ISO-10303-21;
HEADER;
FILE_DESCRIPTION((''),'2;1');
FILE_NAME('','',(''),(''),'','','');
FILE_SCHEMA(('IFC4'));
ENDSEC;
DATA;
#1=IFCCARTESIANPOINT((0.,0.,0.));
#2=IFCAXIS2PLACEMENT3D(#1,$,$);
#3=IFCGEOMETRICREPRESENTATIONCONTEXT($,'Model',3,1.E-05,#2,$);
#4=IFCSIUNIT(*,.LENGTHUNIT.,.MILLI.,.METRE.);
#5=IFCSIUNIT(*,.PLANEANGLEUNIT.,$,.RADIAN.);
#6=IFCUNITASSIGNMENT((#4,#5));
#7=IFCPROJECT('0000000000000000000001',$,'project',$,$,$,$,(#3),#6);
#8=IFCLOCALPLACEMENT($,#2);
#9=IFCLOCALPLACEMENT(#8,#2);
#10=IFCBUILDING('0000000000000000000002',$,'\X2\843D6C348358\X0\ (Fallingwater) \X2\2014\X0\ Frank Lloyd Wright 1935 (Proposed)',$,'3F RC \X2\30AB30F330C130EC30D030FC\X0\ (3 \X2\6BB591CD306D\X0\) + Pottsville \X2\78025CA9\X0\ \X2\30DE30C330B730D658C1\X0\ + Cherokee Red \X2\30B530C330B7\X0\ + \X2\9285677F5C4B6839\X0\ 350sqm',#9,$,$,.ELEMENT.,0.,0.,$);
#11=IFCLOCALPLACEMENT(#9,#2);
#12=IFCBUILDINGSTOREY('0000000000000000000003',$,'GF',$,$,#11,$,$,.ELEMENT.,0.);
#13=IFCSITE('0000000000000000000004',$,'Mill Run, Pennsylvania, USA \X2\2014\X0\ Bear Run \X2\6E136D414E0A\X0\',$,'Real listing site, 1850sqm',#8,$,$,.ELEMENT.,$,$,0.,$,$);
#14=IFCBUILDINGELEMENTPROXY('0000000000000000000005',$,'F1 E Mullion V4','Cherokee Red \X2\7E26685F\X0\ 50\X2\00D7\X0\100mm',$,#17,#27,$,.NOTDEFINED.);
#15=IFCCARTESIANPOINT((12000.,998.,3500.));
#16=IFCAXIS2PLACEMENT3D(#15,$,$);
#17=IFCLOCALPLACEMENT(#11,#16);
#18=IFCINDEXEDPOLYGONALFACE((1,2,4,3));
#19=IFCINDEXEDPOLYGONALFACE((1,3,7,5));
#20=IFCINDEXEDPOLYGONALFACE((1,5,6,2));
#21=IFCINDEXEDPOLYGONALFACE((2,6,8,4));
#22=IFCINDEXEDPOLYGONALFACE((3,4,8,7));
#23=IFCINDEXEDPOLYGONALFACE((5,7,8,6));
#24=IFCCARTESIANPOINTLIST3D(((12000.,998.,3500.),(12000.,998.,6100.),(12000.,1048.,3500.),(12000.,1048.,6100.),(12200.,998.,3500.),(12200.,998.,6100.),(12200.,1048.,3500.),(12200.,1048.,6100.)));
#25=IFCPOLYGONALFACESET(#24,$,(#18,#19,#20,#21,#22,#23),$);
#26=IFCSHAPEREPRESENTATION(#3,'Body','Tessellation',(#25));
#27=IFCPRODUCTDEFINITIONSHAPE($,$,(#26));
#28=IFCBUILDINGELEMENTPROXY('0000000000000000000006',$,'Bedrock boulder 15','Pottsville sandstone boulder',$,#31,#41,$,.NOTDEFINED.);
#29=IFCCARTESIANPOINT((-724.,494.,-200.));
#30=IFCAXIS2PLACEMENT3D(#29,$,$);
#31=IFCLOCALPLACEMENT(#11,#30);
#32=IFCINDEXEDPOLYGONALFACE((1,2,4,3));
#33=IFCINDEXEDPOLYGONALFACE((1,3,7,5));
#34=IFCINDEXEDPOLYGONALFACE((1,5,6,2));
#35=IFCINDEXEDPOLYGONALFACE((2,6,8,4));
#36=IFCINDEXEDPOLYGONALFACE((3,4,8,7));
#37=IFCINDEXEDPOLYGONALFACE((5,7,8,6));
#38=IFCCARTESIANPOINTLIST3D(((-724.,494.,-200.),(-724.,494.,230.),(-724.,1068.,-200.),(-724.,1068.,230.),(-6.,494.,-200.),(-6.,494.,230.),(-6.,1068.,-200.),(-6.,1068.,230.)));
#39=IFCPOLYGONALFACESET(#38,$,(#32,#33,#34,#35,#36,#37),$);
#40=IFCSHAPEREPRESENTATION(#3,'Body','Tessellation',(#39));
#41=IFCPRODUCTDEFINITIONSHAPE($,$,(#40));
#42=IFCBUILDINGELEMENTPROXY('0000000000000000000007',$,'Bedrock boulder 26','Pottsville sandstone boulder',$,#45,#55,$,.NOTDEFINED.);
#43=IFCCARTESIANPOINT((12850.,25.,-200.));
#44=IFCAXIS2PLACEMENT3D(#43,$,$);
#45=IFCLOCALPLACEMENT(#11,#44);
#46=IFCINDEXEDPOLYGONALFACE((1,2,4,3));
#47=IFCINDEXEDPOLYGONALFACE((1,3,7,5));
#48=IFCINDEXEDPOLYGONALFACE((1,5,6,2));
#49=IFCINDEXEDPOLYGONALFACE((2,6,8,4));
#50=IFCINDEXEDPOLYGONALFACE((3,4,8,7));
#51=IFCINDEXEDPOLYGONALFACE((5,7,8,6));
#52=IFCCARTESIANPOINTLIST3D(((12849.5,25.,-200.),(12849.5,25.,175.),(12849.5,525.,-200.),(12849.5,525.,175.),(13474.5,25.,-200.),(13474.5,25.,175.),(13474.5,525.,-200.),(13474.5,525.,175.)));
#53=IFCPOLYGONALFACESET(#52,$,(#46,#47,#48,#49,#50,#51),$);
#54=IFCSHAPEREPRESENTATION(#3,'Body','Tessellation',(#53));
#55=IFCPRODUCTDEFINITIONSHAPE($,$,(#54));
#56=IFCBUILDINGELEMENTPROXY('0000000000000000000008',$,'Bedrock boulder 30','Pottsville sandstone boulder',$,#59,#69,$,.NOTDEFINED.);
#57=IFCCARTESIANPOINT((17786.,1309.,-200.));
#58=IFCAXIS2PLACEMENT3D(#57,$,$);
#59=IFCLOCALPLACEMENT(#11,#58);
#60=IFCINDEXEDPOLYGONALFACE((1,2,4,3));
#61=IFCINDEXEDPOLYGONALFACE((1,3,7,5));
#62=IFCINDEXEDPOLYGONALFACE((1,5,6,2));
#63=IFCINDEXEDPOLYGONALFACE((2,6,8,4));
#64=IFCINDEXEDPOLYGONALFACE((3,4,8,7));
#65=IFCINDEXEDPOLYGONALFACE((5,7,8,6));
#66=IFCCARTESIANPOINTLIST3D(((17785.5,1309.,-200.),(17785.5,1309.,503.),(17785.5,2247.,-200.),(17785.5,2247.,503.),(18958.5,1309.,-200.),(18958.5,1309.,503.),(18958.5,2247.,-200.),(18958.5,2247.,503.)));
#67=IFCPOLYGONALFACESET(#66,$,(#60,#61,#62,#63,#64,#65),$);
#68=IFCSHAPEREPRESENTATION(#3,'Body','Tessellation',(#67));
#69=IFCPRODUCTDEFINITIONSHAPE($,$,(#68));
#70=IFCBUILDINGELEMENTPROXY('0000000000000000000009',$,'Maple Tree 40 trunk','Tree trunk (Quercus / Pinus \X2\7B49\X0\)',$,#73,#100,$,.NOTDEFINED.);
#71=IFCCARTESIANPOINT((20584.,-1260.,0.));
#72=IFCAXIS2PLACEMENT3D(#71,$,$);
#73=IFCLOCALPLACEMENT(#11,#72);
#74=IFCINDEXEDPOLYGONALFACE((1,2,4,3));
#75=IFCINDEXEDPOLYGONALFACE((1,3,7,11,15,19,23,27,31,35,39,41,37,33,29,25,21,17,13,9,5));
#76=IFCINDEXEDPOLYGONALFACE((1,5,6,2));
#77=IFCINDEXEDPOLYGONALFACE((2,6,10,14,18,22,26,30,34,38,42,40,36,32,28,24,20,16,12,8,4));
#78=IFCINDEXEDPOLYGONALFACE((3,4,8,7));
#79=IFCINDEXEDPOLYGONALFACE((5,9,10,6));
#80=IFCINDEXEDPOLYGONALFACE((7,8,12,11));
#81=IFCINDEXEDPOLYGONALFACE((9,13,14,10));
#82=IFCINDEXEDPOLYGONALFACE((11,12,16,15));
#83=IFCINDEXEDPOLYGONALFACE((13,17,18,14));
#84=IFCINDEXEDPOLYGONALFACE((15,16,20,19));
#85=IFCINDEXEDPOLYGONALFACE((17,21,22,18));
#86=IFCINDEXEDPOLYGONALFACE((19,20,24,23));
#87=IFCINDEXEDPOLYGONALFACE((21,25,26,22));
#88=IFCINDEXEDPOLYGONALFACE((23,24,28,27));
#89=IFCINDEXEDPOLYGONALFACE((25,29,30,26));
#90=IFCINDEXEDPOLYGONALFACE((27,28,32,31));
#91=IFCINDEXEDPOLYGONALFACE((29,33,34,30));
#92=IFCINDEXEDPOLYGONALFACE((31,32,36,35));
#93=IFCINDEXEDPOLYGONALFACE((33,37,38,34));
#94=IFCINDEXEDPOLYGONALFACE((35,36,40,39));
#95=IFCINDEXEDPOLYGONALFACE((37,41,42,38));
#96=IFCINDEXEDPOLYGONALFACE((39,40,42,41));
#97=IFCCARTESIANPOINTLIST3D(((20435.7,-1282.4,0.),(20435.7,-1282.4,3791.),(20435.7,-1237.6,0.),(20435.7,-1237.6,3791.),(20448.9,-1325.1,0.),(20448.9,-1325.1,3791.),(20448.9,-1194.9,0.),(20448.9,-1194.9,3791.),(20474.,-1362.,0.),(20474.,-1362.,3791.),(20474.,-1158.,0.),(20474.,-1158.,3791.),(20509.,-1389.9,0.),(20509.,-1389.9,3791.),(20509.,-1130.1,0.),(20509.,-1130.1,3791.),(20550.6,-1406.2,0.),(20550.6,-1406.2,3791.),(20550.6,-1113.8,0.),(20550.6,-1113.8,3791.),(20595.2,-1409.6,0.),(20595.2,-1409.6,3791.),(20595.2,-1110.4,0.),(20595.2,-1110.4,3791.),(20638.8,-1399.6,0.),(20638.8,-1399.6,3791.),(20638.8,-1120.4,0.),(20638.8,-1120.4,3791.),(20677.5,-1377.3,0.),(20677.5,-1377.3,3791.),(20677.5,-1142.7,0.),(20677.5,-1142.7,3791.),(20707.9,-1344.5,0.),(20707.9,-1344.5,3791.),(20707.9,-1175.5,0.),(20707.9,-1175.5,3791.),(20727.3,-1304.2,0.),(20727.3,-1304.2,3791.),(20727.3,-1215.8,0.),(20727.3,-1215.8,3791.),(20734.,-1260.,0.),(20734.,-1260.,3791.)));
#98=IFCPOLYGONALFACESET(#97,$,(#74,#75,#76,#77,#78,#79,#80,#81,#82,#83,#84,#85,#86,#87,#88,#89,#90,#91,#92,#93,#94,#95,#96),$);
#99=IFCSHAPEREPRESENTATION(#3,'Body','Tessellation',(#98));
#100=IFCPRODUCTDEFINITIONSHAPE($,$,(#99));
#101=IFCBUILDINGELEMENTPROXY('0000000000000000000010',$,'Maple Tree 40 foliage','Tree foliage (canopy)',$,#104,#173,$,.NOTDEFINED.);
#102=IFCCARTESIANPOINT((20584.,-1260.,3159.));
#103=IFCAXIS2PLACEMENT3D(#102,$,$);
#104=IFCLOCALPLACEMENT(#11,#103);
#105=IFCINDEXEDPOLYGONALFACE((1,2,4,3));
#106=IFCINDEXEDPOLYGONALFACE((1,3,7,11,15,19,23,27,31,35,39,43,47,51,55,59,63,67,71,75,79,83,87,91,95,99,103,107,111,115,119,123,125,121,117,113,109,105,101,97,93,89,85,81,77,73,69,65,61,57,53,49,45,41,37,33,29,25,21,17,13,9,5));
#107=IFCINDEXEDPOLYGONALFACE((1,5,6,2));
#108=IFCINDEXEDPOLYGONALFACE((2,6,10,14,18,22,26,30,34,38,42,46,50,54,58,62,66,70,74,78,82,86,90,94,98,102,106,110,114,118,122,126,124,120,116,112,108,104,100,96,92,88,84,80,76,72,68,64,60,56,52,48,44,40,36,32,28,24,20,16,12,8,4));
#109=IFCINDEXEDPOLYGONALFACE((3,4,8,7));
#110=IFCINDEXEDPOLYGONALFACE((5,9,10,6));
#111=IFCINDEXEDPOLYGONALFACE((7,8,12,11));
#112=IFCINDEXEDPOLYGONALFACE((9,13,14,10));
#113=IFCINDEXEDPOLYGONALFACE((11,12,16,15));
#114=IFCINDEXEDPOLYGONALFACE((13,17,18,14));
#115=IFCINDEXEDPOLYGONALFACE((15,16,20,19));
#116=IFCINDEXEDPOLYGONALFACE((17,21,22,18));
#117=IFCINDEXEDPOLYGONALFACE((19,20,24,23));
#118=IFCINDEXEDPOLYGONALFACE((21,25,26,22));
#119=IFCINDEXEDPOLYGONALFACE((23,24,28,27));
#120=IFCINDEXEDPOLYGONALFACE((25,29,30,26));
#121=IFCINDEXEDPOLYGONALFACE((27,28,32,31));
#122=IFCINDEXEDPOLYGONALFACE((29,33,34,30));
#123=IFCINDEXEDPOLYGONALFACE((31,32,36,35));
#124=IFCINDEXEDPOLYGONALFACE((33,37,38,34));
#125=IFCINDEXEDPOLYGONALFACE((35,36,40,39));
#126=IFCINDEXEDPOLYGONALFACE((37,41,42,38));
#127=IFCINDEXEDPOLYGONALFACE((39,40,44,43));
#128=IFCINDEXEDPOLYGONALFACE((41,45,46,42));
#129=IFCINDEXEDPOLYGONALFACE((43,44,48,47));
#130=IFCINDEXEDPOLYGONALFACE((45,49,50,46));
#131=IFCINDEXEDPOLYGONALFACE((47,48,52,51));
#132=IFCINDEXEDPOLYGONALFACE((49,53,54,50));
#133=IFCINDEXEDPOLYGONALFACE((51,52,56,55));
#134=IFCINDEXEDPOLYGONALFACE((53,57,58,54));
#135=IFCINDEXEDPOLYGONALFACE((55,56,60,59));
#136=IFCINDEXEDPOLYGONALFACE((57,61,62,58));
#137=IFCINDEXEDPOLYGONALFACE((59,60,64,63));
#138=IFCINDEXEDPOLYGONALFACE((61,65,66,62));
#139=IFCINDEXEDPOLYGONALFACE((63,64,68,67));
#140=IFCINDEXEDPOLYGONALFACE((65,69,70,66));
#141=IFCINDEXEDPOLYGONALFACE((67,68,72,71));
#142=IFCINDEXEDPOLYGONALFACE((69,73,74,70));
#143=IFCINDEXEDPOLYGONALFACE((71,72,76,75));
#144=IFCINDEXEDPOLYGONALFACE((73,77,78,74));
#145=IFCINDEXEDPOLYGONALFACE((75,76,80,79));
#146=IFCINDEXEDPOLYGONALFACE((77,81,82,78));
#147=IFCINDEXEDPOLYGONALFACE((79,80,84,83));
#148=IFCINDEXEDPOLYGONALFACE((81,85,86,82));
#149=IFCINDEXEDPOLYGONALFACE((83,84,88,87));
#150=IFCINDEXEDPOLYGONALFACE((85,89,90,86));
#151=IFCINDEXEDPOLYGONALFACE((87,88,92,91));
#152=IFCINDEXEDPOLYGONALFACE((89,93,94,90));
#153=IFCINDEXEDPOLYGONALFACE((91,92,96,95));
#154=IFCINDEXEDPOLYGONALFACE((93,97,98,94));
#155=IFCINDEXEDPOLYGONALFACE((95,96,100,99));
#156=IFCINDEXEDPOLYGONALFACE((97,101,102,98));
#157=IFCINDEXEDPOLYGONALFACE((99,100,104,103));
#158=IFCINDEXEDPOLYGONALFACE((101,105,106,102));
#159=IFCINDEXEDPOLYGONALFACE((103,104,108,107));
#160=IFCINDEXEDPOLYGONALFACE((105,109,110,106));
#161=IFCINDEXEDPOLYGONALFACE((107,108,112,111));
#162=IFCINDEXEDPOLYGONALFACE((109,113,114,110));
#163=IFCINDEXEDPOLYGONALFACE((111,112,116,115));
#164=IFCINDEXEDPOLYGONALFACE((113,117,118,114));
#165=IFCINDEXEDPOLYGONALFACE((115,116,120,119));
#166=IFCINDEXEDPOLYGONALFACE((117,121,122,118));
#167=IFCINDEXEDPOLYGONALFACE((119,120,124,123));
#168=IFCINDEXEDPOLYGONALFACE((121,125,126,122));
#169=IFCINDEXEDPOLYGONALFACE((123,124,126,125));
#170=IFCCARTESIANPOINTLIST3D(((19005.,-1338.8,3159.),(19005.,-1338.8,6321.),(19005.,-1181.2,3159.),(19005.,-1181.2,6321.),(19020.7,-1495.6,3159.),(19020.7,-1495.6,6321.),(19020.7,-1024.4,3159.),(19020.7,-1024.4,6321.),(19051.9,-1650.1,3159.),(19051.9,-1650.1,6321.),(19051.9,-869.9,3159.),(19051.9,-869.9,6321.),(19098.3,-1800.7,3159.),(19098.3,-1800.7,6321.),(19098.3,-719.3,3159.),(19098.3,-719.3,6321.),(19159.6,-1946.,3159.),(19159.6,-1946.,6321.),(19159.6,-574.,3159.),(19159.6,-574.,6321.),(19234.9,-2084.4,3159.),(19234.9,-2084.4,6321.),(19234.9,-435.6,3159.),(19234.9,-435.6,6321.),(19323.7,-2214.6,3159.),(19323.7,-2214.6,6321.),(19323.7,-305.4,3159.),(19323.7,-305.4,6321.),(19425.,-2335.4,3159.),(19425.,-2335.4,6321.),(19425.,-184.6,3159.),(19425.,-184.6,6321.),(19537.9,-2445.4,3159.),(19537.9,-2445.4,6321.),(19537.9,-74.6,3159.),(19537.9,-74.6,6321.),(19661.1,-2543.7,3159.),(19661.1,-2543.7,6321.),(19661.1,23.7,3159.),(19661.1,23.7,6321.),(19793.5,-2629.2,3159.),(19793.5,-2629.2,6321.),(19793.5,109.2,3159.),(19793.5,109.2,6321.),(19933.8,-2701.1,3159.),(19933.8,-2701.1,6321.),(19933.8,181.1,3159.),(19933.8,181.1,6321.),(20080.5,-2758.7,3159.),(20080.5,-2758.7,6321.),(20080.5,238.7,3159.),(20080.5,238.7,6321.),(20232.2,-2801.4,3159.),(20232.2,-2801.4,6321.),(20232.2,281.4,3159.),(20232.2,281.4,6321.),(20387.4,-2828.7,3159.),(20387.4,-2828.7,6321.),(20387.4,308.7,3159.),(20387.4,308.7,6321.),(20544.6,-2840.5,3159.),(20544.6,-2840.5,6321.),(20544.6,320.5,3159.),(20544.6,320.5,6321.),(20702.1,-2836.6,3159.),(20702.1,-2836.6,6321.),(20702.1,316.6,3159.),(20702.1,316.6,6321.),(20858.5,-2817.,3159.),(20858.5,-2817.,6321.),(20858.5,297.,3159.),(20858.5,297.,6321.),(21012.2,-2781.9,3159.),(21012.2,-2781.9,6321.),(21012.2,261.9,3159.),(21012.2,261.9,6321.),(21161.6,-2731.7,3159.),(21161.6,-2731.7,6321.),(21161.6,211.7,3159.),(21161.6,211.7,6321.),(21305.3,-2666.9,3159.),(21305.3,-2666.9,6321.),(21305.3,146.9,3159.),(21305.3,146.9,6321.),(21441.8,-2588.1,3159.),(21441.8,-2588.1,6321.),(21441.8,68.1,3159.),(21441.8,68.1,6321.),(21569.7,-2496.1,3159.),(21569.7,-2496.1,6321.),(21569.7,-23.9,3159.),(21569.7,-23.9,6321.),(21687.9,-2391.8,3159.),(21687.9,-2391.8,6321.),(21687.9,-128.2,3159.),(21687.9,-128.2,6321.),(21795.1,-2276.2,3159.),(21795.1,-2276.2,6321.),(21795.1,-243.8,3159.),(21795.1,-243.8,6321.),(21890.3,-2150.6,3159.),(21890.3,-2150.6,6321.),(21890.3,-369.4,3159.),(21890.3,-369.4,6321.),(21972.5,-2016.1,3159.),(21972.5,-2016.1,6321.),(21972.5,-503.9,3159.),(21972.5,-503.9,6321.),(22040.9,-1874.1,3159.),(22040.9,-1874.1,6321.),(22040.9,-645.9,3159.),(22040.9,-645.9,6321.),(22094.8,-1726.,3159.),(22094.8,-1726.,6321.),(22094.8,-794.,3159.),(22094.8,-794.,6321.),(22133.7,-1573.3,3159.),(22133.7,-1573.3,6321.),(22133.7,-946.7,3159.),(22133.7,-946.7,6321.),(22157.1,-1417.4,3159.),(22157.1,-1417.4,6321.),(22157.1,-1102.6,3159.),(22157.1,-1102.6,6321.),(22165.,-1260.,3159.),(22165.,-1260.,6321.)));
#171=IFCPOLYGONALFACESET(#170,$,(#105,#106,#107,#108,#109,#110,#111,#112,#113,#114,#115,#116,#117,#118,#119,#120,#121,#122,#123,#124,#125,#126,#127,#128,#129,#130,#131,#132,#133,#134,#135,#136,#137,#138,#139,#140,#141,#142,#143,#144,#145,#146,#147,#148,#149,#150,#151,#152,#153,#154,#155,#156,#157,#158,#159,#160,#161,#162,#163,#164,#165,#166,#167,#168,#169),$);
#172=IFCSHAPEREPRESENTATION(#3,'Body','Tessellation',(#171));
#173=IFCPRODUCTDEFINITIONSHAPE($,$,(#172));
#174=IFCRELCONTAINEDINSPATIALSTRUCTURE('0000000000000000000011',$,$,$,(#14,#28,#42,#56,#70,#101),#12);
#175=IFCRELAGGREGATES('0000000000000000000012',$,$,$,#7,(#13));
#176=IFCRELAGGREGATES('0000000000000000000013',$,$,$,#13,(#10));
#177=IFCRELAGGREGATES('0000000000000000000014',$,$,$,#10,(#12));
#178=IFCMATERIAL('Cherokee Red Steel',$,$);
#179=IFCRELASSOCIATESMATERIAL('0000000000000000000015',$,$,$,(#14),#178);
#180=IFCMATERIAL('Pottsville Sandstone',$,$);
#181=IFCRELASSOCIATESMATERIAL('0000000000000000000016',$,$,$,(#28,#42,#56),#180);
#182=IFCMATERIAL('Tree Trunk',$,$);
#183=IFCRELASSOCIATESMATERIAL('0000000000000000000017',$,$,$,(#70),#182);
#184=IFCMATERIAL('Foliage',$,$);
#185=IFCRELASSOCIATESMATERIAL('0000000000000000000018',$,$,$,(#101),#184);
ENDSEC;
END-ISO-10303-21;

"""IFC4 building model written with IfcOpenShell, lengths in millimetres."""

from ifc_helpers import new_model, si_unit, frame, frame_2d, origin, origin_2d, place, context, project, spatial, rectangle, circle, extrude, material, element, save


model = new_model("IFC4")

# Units and contexts
model_context = context("Model", 3, precision=1e-05, world=origin())
ifc_project = project(units=[si_unit("LENGTHUNIT", "METRE", prefix="MILLI"), si_unit("PLANEANGLEUNIT", "RADIAN")], contexts=[model_context])

# Site, building, storey
site_placement = place(None, origin())
site = spatial("IfcSite", under=ifc_project, at=site_placement, Name="Mill Run, Pennsylvania, USA — Bear Run 渓流上", ObjectType="Real listing site, 1850sqm", CompositionType="ELEMENT", RefElevation=0.0)
building_placement = place(site_placement, origin())
building = spatial("IfcBuilding", under=site, at=building_placement, Name="落水荘 (Fallingwater) — Frank Lloyd Wright 1935 (Proposed)", ObjectType="3F RC カンチレバー (3 段重ね) + Pottsville 砂岩 マッシブ壁 + Cherokee Red サッシ + 銅板屋根 350sqm", CompositionType="ELEMENT", ElevationOfRefHeight=0.0, ElevationOfTerrain=0.0)
storey_placement = place(building_placement, origin())
storey = spatial("IfcBuildingStorey", under=building, at=storey_placement, Name="GF", CompositionType="ELEMENT", Elevation=0.0)

# Shared definitions
ifc_material_1 = material(Name="Pottsville Sandstone")

# Building element proxies
ifc_material_2 = material(Name="Cherokee Red Steel")
proxy_1_placement = place(storey_placement, frame((12000.0, 998.0, 3500.0)))
element("IfcBuildingElementProxy", 1, at=proxy_1_placement, inside=storey, material=ifc_material_2, Name="F1 E Mullion V4", Description="Cherokee Red 縦桟 50×100mm", PredefinedType="NOTDEFINED", context=model_context, shape_type="SweptSolid", body=[
    extrude(rectangle(XDim=200.0, YDim=50.0, at=frame_2d((100.0, 25.0))), frame((12000.0, 998.0, 3500.0)), (0.0, 0.0, 1.0), 2600.0),
])
proxy_2_placement = place(storey_placement, frame((-724.0, 494.0, -200.0)))
element("IfcBuildingElementProxy", 2, at=proxy_2_placement, inside=storey, material=ifc_material_1, Name="Bedrock boulder 15", Description="Pottsville sandstone boulder", PredefinedType="NOTDEFINED", context=model_context, shape_type="SweptSolid", body=[
    extrude(rectangle(XDim=718.0, YDim=574.0, at=frame_2d((359.0, 287.0))), frame((-724.0, 494.0, -200.0)), (0.0, 0.0, 1.0), 430.0),
])
proxy_3_placement = place(storey_placement, frame((12850.0, 25.0, -200.0)))
element("IfcBuildingElementProxy", 3, at=proxy_3_placement, inside=storey, material=ifc_material_1, Name="Bedrock boulder 26", Description="Pottsville sandstone boulder", PredefinedType="NOTDEFINED", context=model_context, shape_type="SweptSolid", body=[
    extrude(rectangle(XDim=625.0, YDim=500.0, at=frame_2d((312.0, 250.0))), frame((12850.0, 25.0, -200.0)), (0.0, 0.0, 1.0), 375.0),
])
proxy_4_placement = place(storey_placement, frame((17786.0, 1309.0, -200.0)))
element("IfcBuildingElementProxy", 4, at=proxy_4_placement, inside=storey, material=ifc_material_1, Name="Bedrock boulder 30", Description="Pottsville sandstone boulder", PredefinedType="NOTDEFINED", context=model_context, shape_type="SweptSolid", body=[
    extrude(rectangle(XDim=1173.0, YDim=938.0, at=frame_2d((586.0, 469.0))), frame((17786.0, 1309.0, -200.0)), (0.0, 0.0, 1.0), 703.0),
])
ifc_material_3 = material(Name="Tree Trunk")
proxy_5_placement = place(storey_placement, frame((20584.0, -1260.0, 0.0)))
element("IfcBuildingElementProxy", 5, at=proxy_5_placement, inside=storey, material=ifc_material_3, Name="Maple Tree 40 trunk", Description="Tree trunk (Quercus / Pinus 等)", PredefinedType="NOTDEFINED", context=model_context, shape_type="SweptSolid", body=[
    extrude(circle(Radius=150.0, at=origin_2d()), frame((20584.0, -1260.0, 0.0)), (0.0, 0.0, 1.0), 3791.0),
])
ifc_material_4 = material(Name="Foliage")
proxy_6_placement = place(storey_placement, frame((20584.0, -1260.0, 3159.0)))
element("IfcBuildingElementProxy", 6, at=proxy_6_placement, inside=storey, material=ifc_material_4, Name="Maple Tree 40 foliage", Description="Tree foliage (canopy)", PredefinedType="NOTDEFINED", context=model_context, shape_type="SweptSolid", body=[
    extrude(circle(Radius=1581.0, at=origin_2d()), frame((20584.0, -1260.0, 3159.0)), (0.0, 0.0, 1.0), 3162.0),
])

save(model, "model.ifc")
